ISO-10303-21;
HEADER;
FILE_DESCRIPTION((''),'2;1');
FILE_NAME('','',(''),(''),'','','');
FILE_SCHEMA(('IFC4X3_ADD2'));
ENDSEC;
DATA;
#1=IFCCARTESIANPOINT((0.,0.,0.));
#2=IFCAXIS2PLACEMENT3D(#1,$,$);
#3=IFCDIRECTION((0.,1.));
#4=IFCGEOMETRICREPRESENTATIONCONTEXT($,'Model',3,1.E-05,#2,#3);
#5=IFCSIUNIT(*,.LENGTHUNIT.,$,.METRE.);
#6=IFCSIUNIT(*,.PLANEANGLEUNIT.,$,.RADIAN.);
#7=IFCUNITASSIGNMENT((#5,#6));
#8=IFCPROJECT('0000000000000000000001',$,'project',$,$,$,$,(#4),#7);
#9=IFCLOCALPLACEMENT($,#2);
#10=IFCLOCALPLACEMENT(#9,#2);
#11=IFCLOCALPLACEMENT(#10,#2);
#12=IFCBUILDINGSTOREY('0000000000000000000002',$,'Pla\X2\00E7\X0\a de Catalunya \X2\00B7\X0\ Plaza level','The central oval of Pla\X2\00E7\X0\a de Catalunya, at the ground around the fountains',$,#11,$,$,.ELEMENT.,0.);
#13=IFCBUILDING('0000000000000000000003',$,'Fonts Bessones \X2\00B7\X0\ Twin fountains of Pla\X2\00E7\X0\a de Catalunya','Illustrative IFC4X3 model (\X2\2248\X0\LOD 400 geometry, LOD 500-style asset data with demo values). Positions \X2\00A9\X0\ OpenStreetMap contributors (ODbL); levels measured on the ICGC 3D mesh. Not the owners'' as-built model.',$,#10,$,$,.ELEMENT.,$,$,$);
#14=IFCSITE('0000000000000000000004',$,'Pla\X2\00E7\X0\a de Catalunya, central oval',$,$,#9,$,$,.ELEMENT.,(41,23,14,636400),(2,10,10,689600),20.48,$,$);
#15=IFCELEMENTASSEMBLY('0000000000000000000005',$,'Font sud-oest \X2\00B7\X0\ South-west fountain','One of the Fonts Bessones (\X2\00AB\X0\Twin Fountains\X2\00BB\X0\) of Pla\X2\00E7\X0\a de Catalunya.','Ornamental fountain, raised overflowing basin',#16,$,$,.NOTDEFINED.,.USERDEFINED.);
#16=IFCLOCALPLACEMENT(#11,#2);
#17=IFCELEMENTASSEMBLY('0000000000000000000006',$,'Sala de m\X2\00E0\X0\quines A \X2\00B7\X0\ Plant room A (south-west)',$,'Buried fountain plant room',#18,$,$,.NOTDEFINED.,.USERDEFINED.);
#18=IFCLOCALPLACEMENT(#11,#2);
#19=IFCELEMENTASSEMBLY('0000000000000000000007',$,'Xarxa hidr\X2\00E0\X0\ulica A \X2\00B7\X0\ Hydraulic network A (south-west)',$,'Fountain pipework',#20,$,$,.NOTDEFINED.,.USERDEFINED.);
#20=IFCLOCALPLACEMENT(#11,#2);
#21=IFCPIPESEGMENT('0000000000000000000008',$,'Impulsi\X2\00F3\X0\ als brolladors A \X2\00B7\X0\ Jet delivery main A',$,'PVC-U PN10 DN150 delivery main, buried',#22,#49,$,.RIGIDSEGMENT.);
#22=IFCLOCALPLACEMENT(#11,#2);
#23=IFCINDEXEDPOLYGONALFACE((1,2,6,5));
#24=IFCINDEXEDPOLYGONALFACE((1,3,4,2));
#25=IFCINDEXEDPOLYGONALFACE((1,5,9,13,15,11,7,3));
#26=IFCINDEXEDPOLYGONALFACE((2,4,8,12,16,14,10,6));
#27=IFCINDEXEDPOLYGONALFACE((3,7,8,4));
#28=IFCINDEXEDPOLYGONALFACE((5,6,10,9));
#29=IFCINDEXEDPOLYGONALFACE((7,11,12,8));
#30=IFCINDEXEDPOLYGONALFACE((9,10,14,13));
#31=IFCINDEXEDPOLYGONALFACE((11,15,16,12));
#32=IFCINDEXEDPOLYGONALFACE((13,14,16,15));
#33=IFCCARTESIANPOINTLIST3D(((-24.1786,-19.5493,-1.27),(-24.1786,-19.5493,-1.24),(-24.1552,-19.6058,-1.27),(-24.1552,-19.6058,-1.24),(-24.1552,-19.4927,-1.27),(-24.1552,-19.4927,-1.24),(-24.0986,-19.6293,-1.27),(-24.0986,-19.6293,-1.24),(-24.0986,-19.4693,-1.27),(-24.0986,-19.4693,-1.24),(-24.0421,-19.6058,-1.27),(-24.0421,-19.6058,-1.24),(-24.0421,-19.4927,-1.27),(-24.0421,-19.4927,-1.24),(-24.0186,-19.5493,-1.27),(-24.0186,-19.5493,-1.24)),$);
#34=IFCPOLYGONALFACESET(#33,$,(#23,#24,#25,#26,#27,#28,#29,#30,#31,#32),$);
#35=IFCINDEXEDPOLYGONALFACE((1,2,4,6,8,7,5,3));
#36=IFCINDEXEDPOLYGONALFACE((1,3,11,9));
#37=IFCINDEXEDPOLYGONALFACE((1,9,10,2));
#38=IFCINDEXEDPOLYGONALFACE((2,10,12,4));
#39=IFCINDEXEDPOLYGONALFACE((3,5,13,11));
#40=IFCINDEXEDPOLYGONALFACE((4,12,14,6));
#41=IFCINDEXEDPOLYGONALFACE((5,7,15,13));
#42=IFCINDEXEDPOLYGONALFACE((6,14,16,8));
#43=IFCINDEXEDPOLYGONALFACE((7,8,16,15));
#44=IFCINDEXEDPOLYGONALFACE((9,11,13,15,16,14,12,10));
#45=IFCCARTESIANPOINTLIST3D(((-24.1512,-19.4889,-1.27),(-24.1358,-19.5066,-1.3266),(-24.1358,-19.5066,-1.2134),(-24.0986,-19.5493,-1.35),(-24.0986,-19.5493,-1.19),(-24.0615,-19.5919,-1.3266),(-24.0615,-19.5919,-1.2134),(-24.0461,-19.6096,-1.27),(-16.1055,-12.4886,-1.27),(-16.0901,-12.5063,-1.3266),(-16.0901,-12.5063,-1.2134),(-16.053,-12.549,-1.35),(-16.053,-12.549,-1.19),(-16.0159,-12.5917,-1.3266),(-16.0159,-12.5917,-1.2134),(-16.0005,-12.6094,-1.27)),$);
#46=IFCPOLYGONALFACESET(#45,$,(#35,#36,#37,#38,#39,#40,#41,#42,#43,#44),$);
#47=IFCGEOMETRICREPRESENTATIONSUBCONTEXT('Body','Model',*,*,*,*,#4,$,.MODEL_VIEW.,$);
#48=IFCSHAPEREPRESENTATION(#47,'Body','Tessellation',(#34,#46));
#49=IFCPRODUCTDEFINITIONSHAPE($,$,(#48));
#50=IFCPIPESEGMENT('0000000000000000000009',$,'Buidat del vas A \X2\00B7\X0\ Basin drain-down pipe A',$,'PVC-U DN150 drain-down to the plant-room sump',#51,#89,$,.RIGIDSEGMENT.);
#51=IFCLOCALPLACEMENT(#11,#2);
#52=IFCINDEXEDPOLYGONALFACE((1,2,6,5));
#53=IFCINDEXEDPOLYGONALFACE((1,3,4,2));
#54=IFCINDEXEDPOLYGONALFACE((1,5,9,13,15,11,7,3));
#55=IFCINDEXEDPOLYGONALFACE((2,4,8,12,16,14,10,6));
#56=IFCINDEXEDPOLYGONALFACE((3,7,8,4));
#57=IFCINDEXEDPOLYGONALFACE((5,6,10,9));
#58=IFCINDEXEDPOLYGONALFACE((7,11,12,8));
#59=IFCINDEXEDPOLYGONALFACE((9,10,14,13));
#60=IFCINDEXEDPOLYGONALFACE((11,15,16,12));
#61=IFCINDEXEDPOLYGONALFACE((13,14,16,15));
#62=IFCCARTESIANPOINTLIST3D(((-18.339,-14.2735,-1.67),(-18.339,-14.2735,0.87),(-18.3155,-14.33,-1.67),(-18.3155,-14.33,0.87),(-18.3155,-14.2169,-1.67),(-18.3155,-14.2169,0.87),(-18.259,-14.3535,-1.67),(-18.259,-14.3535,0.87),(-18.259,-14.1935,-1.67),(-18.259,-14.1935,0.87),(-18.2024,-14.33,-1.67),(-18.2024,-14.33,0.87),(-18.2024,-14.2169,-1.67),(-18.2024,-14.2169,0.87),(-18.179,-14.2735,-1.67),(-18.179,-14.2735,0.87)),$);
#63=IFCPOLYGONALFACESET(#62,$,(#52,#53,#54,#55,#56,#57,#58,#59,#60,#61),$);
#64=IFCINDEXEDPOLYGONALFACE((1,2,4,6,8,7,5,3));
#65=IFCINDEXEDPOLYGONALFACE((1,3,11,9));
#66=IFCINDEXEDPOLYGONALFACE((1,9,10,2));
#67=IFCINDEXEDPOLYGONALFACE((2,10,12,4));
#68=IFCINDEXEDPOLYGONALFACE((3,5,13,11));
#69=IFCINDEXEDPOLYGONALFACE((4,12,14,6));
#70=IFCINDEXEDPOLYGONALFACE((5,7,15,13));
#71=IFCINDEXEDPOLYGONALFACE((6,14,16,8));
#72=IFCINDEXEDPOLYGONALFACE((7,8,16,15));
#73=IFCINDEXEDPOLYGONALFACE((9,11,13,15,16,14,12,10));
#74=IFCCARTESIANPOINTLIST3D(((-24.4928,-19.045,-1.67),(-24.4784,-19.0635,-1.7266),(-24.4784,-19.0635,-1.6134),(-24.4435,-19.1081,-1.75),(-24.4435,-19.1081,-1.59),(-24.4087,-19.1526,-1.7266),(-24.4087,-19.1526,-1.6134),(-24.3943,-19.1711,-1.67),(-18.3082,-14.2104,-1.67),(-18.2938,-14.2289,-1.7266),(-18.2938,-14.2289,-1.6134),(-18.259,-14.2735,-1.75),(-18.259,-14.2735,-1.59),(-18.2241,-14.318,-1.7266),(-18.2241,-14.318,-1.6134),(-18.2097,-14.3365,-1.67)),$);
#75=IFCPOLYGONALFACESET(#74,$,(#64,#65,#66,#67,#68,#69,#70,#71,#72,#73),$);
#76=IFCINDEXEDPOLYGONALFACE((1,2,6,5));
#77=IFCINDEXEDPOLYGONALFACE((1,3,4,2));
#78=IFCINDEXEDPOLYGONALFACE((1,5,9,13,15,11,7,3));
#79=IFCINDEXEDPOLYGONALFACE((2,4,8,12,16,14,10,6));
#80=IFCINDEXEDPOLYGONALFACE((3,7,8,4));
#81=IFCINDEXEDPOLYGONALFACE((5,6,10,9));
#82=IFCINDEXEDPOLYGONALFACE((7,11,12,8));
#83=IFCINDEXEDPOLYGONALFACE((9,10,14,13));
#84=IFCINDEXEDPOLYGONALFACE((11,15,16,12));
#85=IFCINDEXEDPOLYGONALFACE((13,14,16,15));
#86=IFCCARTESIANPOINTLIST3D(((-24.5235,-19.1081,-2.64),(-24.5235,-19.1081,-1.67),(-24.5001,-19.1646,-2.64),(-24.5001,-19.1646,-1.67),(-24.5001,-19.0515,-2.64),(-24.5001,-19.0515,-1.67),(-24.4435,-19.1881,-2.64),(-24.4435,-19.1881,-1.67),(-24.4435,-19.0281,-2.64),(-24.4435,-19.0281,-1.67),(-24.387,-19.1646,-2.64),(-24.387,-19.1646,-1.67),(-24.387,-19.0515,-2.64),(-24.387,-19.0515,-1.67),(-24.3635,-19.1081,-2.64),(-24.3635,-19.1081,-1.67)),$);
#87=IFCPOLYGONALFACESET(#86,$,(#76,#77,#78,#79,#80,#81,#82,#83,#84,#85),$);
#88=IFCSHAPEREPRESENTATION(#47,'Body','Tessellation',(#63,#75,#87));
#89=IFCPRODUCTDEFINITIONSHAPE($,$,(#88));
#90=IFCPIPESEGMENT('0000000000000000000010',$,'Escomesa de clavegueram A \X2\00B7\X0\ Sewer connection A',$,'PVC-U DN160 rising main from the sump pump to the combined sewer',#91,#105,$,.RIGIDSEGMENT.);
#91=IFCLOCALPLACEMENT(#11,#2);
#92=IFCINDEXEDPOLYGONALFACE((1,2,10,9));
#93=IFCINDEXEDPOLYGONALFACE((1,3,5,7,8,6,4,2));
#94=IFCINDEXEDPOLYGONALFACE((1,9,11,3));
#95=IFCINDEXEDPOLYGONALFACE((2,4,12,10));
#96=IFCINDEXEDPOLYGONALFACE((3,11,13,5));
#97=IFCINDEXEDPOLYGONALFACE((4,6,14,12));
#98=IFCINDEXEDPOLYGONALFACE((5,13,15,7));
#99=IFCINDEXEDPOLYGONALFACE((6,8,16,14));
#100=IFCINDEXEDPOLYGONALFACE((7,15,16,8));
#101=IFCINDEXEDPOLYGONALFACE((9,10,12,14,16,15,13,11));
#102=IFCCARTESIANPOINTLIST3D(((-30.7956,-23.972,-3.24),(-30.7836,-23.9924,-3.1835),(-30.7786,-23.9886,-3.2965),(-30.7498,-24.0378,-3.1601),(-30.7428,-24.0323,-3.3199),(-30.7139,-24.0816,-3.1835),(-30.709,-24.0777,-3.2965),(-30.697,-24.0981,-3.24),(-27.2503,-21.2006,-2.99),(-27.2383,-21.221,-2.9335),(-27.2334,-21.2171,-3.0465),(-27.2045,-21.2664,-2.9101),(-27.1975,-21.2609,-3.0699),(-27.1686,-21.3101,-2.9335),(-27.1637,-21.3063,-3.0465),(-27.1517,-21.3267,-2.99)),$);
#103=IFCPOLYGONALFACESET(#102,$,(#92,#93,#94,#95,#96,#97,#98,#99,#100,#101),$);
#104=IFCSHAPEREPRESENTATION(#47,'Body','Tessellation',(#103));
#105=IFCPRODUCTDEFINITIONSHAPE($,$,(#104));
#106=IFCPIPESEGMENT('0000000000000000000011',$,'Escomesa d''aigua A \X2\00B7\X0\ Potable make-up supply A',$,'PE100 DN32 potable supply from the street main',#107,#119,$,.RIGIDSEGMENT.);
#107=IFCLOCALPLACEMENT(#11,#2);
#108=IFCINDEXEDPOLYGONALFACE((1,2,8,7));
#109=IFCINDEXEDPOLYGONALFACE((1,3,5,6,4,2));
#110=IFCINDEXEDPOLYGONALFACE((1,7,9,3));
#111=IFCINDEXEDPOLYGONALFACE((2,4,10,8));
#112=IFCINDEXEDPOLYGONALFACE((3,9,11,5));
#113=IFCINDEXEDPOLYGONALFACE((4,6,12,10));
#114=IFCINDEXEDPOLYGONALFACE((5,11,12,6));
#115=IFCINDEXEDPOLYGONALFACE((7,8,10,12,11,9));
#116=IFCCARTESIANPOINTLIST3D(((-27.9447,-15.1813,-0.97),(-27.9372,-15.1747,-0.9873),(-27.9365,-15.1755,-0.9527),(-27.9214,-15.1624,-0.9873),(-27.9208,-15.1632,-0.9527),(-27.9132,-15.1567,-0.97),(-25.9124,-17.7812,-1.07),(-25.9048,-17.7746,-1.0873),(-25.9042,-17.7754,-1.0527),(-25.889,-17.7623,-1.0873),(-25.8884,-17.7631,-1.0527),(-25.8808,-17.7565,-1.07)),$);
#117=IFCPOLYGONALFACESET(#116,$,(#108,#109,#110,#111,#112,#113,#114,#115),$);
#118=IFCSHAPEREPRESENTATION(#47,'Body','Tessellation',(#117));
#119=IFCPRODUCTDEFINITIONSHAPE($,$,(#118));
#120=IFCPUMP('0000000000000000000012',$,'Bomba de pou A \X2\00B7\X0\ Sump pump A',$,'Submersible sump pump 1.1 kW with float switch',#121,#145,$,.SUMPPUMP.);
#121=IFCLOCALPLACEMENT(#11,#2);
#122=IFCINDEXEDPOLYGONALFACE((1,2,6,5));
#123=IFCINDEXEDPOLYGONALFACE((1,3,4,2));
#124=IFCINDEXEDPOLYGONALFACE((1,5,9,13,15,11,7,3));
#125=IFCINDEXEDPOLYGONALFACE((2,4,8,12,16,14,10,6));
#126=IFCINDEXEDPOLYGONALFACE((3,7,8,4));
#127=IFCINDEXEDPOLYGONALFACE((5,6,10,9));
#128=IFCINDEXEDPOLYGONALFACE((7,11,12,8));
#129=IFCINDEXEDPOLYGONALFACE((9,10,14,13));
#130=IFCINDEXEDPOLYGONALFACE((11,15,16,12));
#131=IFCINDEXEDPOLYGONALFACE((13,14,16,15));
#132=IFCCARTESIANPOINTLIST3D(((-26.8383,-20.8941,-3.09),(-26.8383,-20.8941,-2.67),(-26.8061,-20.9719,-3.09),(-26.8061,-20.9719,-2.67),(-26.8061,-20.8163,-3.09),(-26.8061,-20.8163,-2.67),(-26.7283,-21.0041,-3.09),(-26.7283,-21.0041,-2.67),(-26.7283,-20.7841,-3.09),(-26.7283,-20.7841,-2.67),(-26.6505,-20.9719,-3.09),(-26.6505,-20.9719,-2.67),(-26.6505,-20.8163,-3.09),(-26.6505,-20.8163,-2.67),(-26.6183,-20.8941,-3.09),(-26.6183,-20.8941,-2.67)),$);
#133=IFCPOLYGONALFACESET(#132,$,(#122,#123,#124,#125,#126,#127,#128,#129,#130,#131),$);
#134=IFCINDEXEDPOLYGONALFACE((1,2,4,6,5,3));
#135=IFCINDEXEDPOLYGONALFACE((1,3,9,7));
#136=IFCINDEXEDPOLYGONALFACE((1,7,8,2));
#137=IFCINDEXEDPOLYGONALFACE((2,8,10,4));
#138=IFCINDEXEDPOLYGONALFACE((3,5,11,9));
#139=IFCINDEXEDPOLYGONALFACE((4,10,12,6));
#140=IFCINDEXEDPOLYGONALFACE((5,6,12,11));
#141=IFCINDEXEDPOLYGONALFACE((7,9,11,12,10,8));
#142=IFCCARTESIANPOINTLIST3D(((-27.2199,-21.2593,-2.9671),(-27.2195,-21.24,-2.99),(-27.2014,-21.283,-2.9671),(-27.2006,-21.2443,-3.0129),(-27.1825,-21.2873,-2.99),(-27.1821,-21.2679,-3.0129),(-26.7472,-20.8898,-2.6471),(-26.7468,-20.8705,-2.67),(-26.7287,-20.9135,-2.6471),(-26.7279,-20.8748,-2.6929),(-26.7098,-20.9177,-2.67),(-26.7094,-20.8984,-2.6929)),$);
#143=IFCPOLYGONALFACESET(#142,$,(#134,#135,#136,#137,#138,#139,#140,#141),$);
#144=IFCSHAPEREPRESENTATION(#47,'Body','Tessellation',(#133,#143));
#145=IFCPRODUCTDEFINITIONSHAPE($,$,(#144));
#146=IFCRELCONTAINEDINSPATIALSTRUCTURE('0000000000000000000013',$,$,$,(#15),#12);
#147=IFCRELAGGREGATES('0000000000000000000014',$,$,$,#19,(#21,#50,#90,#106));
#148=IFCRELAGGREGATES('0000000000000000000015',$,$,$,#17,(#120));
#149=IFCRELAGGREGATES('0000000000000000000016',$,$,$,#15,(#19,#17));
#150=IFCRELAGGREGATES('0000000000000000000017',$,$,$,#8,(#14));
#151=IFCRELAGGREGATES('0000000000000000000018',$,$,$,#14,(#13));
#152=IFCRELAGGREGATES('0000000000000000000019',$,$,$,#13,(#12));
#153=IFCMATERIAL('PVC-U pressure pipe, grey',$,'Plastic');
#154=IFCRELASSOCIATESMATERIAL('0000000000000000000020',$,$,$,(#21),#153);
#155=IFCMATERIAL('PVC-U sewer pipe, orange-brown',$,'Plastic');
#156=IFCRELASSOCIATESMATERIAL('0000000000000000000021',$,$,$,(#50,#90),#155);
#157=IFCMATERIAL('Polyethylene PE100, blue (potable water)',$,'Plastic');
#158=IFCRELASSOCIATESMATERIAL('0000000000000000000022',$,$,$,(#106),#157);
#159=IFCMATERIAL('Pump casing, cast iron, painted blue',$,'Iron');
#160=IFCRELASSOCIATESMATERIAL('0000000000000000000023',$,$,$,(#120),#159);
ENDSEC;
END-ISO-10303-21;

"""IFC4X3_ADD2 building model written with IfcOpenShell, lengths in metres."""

from ifc_helpers import new_model, si_unit, direction, frame, origin, place, context, subcontext, project, spatial, polyline, outline, extrude, material, element, aggregate, save


model = new_model("IFC4X3_ADD2")

# Units and contexts
model_context = context("Model", 3, precision=1e-05, world=origin(), true_north=direction((0.0, 1.0)))
body_context = subcontext(model_context, "Body", "Model", "MODEL_VIEW")
ifc_project = project(units=[si_unit("LENGTHUNIT", "METRE"), si_unit("PLANEANGLEUNIT", "RADIAN")], contexts=[model_context])

# Site, building, storey
site_placement = place(None, origin())
site = spatial("IfcSite", under=ifc_project, at=site_placement, Name="Plaça de Catalunya, central oval", CompositionType="ELEMENT", RefLatitude=(41, 23, 14, 636400), RefLongitude=(2, 10, 10, 689600), RefElevation=20.48)
building_placement = place(site_placement, origin())
building = spatial("IfcBuilding", under=site, at=building_placement, Name="Fonts Bessones · Twin fountains of Plaça de Catalunya", Description="Illustrative IFC4X3 model (≈LOD 400 geometry, LOD 500-style asset data with demo values). Positions © OpenStreetMap contributors (ODbL); levels measured on the ICGC 3D mesh. Not the owners' as-built model.", CompositionType="ELEMENT")
storey_placement = place(building_placement, origin())
storey = spatial("IfcBuildingStorey", under=building, at=storey_placement, Name="Plaça de Catalunya · Plaza level", Description="The central oval of Plaça de Catalunya, at the ground around the fountains", CompositionType="ELEMENT", Elevation=0.0)

# Element assemblies
assembly_1_placement = place(building_placement, origin())
assembly_1 = element("IfcElementAssembly", 1, at=assembly_1_placement, inside=storey, Name="Font sud-oest · South-west fountain", Description="One of the Fonts Bessones («Twin Fountains») of Plaça de Catalunya.", ObjectType="Ornamental fountain, raised overflowing basin", AssemblyPlace="NOTDEFINED", PredefinedType="USERDEFINED")
assembly_2_placement = place(building_placement, origin())
assembly_2 = element("IfcElementAssembly", 2, at=assembly_2_placement, Name="Sala de màquines A · Plant room A (south-west)", ObjectType="Buried fountain plant room", AssemblyPlace="NOTDEFINED", PredefinedType="USERDEFINED")

# Element assembly
assembly_3_placement = place(building_placement, origin())
assembly_3 = element("IfcElementAssembly", 3, at=assembly_3_placement, Name="Xarxa hidràulica A · Hydraulic network A (south-west)", ObjectType="Fountain pipework", AssemblyPlace="NOTDEFINED", PredefinedType="USERDEFINED")

# Shared definitions
ifc_material_1 = material(Name="Pump casing, cast iron, painted blue", Category="Iron")

# Shared definitions
ifc_material_2 = material(Name="PVC-U pressure pipe, grey", Category="Plastic")

# Pipe segments
pipe_segment_1_placement = place(building_placement, origin())
pipe_segment_1 = element("IfcPipeSegment", 4, at=pipe_segment_1_placement, material=ifc_material_2, Name="Impulsió als brolladors A · Jet delivery main A", ObjectType="PVC-U PN10 DN150 delivery main, buried", PredefinedType="RIGIDSEGMENT", context=body_context, shape_type="SweptSolid", body=[
    extrude(outline(polyline([(0.08, 0.0), (0.0566, 0.0566), (0.0, 0.08), (-0.0566, 0.0566), (-0.08, 0.0), (-0.0566, -0.0566), (0.0, -0.08), (0.0566, -0.0566), (0.08, 0.0)])), frame((-24.0986, -19.5493, -1.24), z_axis=(0.0, 0.0, -1.0), x_axis=(0.0, -1.0, 0.0)), (0.0, 0.0, 1.0), 0.03),
    extrude(outline(polyline([(0.08, 0.0), (0.0566, 0.0566), (0.0, 0.08), (-0.0566, 0.0566), (-0.08, 0.0), (-0.0566, -0.0566), (0.0, -0.08), (0.0566, -0.0566), (0.08, 0.0)])), frame((-24.0986, -19.5493, -1.27), z_axis=(0.754417, 0.656395, 0.0), x_axis=(0.656395, -0.754417, 0.0)), (0.0, 0.0, 1.0), 10.6647),
])
ifc_material_3 = material(Name="PVC-U sewer pipe, orange-brown", Category="Plastic")
pipe_segment_2_placement = place(building_placement, origin())
pipe_segment_2 = element("IfcPipeSegment", 5, at=pipe_segment_2_placement, material=ifc_material_3, Name="Buidat del vas A · Basin drain-down pipe A", ObjectType="PVC-U DN150 drain-down to the plant-room sump", PredefinedType="RIGIDSEGMENT", context=body_context, shape_type="SweptSolid", body=[
    extrude(outline(polyline([(0.08, 0.0), (0.0566, 0.0566), (0.0, 0.08), (-0.0566, 0.0566), (-0.08, 0.0), (-0.0566, -0.0566), (0.0, -0.08), (0.0566, -0.0566), (0.08, 0.0)])), frame((-18.259, -14.2735, 0.87), z_axis=(0.0, 0.0, -1.0), x_axis=(0.0, -1.0, 0.0)), (0.0, 0.0, 1.0), 2.54),
    extrude(outline(polyline([(0.08, 0.0), (0.0566, 0.0566), (0.0, 0.08), (-0.0566, 0.0566), (-0.08, 0.0), (-0.0566, -0.0566), (0.0, -0.08), (0.0566, -0.0566), (0.08, 0.0)])), frame((-18.259, -14.2735, -1.67), z_axis=(-0.787844, -0.615875, 0.0), x_axis=(-0.615875, 0.787844, 0.0)), (0.0, 0.0, 1.0), 7.85),
    extrude(outline(polyline([(0.08, 0.0), (0.0566, 0.0566), (0.0, 0.08), (-0.0566, 0.0566), (-0.08, 0.0), (-0.0566, -0.0566), (0.0, -0.08), (0.0566, -0.0566), (0.08, 0.0)])), frame((-24.4435, -19.1081, -1.67), z_axis=(0.0, 0.0, -1.0), x_axis=(0.0, -1.0, 0.0)), (0.0, 0.0, 1.0), 0.97),
])
pipe_segment_3_placement = place(building_placement, origin())
pipe_segment_3 = element("IfcPipeSegment", 6, at=pipe_segment_3_placement, material=ifc_material_3, Name="Escomesa de clavegueram A · Sewer connection A", ObjectType="PVC-U DN160 rising main from the sump pump to the combined sewer", PredefinedType="RIGIDSEGMENT", context=body_context, shape_type="SweptSolid", body=[
    extrude(outline(polyline([(0.08, 0.0), (0.0566, 0.0566), (0.0, 0.08), (-0.0566, 0.0566), (-0.08, 0.0), (-0.0566, -0.0566), (0.0, -0.08), (0.0566, -0.0566), (0.08, 0.0)])), frame((-27.201, -21.2636, -2.99), z_axis=(-0.786631, -0.614927, -0.05547), x_axis=(-0.615875, 0.787844, 0.0)), (0.0, 0.0, 1.0), 4.5069),
])
ifc_material_4 = material(Name="Polyethylene PE100, blue (potable water)", Category="Plastic")
pipe_segment_4_placement = place(building_placement, origin())
pipe_segment_4 = element("IfcPipeSegment", 7, at=pipe_segment_4_placement, material=ifc_material_4, Name="Escomesa d'aigua A · Potable make-up supply A", ObjectType="PE100 DN32 potable supply from the street main", PredefinedType="RIGIDSEGMENT", context=body_context, shape_type="SweptSolid", body=[
    extrude(outline(polyline([(0.02, 0.0), (0.01, 0.0173), (-0.01, 0.0173), (-0.02, 0.0), (-0.01, -0.0173), (0.01, -0.0173), (0.02, 0.0)])), frame((-25.8966, -17.7689, -1.07), z_axis=(-0.615593, 0.787482, 0.030289), x_axis=(0.787844, 0.615875, 0.0)), (0.0, 0.0, 1.0), 3.3015),
])
aggregate(assembly_3, [pipe_segment_1, pipe_segment_2, pipe_segment_3, pipe_segment_4])

# Pump
pump_1_placement = place(building_placement, origin())
pump_1 = element("IfcPump", 8, at=pump_1_placement, material=ifc_material_1, Name="Bomba de pou A · Sump pump A", ObjectType="Submersible sump pump 1.1 kW with float switch", PredefinedType="SUMPPUMP", context=body_context, shape_type="SweptSolid", body=[
    extrude(outline(polyline([(-26.6183, -20.8941), (-26.6505, -20.8163), (-26.7283, -20.7841), (-26.8061, -20.8163), (-26.8383, -20.8941), (-26.8061, -20.9719), (-26.7283, -21.0041), (-26.6505, -20.9719), (-26.6183, -20.8941)])), frame((0.0, 0.0, -3.09)), (0.0, 0.0, 1.0), 0.42),
    extrude(outline(polyline([(0.03, 0.0), (0.015, 0.026), (-0.015, 0.026), (-0.03, 0.0), (-0.015, -0.026), (0.015, -0.026), (0.03, 0.0)])), frame((-26.7283, -20.8941, -2.67), z_axis=(-0.695156, -0.54342, -0.470588), x_axis=(-0.615875, 0.787844, 0.0)), (0.0, 0.0, 1.0), 0.68),
])
aggregate(assembly_2, [pump_1])

aggregate(assembly_1, [assembly_3, assembly_2])

save(model, "model.ifc")
